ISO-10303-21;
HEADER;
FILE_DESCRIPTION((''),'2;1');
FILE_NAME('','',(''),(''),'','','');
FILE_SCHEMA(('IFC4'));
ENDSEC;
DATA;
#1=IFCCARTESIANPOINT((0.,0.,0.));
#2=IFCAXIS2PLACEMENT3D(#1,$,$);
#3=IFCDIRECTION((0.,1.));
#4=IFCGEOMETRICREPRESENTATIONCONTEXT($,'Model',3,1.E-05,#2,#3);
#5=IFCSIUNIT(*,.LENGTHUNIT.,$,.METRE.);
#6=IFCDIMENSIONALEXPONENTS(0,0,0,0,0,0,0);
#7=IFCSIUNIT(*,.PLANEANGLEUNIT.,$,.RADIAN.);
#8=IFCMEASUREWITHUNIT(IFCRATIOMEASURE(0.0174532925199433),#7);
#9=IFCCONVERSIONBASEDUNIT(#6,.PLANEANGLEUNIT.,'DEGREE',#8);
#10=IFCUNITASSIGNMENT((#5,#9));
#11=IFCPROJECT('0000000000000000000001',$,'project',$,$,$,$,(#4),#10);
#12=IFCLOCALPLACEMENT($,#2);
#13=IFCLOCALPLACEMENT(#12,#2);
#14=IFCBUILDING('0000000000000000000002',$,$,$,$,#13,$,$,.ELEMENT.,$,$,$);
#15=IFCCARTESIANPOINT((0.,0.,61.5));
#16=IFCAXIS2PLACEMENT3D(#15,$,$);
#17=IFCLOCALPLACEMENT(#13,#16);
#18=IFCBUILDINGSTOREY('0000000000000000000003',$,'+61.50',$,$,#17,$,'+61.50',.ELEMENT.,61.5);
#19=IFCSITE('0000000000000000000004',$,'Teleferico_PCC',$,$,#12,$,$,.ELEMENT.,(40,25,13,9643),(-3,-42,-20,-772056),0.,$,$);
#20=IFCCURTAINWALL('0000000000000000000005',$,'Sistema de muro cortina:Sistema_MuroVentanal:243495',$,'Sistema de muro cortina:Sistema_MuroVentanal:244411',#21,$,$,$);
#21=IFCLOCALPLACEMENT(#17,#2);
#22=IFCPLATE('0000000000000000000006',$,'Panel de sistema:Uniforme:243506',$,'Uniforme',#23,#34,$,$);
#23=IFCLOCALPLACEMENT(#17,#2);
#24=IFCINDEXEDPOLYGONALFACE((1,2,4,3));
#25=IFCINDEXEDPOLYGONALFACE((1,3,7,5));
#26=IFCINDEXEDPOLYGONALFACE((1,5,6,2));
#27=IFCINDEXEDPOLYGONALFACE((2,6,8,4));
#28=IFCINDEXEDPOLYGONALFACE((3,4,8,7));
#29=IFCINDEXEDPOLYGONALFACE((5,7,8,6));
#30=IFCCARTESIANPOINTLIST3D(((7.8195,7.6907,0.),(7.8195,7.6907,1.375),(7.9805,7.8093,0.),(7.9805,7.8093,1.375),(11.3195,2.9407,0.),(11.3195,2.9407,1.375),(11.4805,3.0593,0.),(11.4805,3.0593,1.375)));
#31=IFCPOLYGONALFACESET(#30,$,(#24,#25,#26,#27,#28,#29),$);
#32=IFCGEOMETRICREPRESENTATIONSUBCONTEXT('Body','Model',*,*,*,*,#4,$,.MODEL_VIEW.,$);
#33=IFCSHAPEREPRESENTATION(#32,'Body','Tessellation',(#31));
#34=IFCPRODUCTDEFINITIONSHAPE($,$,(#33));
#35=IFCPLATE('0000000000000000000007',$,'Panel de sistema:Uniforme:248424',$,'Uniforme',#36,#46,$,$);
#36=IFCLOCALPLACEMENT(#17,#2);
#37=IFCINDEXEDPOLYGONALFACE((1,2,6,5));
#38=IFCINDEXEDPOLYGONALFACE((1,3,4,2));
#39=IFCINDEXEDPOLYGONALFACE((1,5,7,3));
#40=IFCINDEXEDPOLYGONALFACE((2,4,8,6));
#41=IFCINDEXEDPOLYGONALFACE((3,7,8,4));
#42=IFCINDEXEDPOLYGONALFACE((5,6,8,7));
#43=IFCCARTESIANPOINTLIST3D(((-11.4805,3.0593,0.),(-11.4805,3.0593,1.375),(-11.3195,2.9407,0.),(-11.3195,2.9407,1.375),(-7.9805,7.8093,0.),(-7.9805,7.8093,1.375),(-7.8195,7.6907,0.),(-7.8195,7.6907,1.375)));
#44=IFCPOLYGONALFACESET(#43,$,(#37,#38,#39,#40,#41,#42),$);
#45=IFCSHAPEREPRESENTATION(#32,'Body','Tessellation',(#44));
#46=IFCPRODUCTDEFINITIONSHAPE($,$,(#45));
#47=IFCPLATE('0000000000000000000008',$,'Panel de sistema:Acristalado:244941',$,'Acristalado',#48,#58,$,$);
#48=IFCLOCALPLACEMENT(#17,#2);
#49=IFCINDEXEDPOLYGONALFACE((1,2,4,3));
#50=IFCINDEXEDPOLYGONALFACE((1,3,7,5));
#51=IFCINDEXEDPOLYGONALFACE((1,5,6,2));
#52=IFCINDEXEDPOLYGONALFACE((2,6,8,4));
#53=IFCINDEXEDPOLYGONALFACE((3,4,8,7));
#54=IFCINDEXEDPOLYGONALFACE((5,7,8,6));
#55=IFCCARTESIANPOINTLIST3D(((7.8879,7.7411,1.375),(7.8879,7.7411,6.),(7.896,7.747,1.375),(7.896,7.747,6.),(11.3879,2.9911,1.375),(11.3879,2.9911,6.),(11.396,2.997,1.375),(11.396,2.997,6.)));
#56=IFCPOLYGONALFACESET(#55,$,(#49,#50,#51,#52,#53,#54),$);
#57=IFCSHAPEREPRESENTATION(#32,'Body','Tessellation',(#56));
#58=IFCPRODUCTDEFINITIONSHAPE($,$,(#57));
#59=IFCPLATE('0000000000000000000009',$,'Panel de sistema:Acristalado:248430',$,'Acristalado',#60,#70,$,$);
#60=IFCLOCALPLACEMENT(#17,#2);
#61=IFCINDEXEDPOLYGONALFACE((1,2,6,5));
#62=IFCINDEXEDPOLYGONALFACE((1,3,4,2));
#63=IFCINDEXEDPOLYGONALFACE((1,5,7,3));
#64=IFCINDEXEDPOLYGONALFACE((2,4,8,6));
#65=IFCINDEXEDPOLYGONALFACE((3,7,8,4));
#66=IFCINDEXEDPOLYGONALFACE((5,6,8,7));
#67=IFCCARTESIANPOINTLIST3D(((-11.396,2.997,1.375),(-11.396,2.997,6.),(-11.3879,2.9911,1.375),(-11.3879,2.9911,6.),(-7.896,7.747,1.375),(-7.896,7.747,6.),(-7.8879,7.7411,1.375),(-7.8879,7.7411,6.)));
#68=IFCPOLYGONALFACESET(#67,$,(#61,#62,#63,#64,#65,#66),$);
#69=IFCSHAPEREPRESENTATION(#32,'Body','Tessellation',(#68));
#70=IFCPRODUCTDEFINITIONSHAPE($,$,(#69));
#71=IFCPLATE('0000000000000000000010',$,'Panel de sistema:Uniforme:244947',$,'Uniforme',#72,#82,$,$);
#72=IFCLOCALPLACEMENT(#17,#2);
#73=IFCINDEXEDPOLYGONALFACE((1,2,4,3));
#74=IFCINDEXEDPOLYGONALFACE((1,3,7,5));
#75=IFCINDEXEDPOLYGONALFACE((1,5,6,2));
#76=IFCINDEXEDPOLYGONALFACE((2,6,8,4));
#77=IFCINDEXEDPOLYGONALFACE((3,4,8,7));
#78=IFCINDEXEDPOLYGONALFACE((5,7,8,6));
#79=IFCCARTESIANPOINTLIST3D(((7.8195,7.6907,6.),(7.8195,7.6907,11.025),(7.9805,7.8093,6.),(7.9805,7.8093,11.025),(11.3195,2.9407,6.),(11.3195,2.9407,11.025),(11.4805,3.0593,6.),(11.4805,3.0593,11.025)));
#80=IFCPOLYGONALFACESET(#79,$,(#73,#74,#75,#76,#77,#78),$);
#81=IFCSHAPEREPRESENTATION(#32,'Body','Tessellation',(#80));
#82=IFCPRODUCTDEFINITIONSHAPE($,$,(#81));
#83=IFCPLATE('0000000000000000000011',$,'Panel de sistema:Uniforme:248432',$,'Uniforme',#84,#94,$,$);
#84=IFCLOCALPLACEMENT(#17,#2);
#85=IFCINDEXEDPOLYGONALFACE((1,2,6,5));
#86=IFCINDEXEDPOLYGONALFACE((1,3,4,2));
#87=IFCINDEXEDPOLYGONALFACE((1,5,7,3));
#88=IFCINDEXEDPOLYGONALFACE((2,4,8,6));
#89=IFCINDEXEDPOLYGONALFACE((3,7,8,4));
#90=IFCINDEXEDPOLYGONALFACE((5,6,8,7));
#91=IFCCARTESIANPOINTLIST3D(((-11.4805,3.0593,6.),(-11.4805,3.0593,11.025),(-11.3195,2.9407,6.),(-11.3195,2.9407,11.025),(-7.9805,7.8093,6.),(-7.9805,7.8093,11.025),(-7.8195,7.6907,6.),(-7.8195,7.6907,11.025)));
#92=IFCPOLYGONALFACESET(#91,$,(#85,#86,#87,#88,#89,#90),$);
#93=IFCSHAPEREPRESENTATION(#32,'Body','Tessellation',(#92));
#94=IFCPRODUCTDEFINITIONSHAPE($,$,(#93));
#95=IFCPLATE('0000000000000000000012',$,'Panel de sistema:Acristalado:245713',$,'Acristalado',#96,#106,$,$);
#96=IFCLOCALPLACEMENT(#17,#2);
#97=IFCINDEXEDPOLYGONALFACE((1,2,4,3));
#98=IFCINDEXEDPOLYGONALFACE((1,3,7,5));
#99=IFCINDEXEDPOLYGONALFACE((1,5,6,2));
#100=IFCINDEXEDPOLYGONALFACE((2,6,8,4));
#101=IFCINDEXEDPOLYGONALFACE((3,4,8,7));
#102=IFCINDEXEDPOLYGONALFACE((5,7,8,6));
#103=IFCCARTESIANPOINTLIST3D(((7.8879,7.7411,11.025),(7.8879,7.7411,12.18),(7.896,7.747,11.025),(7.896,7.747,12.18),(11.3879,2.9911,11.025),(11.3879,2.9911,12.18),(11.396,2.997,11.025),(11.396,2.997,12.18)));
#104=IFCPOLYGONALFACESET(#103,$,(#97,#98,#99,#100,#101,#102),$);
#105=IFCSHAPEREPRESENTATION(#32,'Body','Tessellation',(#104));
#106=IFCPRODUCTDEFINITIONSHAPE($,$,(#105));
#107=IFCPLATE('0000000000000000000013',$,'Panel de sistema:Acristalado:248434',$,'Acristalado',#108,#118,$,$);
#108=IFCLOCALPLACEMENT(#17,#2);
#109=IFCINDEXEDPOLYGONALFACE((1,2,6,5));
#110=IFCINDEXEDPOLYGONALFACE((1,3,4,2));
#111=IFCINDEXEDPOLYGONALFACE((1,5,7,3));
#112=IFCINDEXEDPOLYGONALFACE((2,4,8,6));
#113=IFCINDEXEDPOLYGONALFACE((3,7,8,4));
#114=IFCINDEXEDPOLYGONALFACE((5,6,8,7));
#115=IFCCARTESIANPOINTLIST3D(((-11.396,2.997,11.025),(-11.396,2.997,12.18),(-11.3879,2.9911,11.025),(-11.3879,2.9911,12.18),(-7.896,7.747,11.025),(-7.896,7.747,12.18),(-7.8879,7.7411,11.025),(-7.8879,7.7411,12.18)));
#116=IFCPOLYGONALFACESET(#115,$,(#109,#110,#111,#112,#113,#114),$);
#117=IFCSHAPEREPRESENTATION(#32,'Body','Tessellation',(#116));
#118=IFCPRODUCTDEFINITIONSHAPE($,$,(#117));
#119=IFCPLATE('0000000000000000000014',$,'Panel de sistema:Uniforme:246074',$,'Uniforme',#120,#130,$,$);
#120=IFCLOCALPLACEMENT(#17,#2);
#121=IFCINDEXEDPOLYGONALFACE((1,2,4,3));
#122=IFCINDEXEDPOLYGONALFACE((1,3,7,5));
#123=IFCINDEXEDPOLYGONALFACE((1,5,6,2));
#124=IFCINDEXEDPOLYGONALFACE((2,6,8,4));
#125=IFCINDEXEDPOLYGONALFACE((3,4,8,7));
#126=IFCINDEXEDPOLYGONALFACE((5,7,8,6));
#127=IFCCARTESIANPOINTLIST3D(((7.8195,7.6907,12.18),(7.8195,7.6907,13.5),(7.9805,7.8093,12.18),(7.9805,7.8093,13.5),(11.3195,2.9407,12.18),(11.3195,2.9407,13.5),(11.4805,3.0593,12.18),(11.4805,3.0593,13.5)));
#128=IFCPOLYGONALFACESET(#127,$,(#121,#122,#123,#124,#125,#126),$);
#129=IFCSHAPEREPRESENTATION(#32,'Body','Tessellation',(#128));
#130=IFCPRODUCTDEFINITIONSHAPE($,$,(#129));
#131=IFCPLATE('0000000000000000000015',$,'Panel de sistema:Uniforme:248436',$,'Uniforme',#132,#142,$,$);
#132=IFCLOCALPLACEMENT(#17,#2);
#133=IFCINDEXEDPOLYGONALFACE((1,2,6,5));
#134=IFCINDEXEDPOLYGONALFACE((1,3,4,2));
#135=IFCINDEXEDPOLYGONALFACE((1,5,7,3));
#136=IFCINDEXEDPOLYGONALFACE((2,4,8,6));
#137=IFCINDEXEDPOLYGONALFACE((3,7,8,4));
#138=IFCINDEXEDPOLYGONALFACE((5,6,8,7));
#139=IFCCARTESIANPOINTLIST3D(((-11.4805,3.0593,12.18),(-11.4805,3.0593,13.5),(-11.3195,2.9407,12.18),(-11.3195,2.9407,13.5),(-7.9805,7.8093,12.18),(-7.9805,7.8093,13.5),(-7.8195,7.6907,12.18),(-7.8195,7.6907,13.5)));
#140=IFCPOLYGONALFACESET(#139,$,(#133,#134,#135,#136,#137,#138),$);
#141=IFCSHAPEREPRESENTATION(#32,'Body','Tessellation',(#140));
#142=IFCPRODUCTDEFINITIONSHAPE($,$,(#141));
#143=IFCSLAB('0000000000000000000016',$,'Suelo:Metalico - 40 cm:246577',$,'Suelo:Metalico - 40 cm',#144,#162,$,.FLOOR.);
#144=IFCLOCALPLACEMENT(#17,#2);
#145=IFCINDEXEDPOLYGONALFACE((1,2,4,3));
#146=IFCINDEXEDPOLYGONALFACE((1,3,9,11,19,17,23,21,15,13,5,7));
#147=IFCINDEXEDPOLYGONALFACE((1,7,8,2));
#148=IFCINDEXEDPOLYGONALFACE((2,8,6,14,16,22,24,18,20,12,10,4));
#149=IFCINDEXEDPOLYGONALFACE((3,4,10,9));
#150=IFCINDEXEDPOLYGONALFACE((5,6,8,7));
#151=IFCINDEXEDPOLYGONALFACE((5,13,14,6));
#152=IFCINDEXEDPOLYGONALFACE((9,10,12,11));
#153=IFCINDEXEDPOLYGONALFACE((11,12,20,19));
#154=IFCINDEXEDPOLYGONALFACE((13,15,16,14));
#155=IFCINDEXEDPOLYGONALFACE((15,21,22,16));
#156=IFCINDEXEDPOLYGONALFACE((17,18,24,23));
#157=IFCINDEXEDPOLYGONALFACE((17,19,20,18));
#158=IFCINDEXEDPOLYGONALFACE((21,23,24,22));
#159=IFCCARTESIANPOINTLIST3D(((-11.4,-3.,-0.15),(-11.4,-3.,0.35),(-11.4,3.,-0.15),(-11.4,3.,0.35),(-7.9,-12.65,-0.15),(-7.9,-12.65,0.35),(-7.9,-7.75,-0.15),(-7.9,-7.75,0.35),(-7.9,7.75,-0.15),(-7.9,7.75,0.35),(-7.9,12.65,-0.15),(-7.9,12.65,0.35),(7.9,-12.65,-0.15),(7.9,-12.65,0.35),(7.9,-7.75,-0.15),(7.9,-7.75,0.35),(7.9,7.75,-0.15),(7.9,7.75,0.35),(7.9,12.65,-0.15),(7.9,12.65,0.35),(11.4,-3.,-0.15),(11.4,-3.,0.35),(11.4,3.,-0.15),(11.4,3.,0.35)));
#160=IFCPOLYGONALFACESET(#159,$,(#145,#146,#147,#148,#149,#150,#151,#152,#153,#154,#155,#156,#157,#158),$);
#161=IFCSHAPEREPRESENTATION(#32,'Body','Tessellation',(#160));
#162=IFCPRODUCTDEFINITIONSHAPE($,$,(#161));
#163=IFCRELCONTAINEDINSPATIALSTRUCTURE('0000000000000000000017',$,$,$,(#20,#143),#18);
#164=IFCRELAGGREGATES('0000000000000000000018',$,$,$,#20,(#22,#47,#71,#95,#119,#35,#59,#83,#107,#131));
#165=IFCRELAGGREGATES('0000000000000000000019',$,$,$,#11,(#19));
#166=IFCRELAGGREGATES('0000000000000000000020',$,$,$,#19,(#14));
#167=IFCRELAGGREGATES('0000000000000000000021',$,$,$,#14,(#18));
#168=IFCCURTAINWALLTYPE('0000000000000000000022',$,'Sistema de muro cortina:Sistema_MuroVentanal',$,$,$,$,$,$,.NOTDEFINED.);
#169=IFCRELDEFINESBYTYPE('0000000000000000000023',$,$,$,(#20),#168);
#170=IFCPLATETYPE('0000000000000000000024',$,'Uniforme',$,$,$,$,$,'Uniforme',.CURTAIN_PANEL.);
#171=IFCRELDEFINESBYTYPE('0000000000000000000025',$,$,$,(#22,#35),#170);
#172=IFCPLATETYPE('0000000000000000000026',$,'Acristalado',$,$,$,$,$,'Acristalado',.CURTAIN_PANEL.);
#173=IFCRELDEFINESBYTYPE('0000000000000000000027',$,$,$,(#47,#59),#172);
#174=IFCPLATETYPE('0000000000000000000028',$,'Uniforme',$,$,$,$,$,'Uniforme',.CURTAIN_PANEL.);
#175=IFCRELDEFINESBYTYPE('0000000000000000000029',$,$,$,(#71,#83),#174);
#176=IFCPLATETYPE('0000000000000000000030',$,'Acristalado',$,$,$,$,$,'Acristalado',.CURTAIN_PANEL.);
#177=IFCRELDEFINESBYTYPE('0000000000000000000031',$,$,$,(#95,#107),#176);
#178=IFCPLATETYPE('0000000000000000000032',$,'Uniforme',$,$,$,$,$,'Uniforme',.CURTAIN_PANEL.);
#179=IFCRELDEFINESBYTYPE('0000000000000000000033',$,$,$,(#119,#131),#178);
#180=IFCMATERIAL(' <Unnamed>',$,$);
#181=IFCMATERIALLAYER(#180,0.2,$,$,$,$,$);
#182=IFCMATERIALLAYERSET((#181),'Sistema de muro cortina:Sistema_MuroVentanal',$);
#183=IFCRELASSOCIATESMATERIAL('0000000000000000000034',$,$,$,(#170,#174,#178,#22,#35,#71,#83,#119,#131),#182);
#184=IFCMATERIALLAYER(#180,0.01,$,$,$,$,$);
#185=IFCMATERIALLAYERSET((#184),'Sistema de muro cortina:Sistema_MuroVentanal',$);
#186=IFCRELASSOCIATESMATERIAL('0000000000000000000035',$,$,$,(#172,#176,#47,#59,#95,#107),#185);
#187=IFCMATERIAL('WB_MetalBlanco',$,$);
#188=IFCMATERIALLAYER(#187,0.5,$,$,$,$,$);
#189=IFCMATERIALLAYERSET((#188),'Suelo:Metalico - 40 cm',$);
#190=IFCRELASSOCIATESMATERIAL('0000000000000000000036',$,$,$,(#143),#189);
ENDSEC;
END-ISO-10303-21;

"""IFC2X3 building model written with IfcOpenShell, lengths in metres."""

from ifc_helpers import new_model, entity, si_unit, converted_unit, direction, frame, frame_2d, origin, origin_2d_with_axis, place, context, subcontext, project, spatial, polyline, rectangle, outline, extrude, source, transform, mapped, material, layer, layer_set, layer_usage, type_object, type_shapes, element, aggregate, save


model = new_model("IFC2X3")

# Units and contexts
model_context = context("Model", 3, precision=1e-05, world=origin(), true_north=direction((0.0, 1.0)))
body_context = subcontext(model_context, "Body", "Model", "MODEL_VIEW")
ifc_project = project(units=[si_unit("LENGTHUNIT", "METRE"), converted_unit("PLANEANGLEUNIT", "DEGREE", entity("IfcRatioMeasure", 0.0174532925199433), si_unit("PLANEANGLEUNIT", "RADIAN"), dimensions=[0, 0, 0, 0, 0, 0, 0])], contexts=[model_context])

# Site, building, storey
site_placement = place(None, origin())
site = spatial("IfcSite", under=ifc_project, at=site_placement, Name="Teleferico_PCC", CompositionType="ELEMENT", RefLatitude=(40, 25, 13, 9643), RefLongitude=(-3, -42, -20, -772056), RefElevation=0.0)
building_placement = place(site_placement, origin())
building = spatial("IfcBuilding", under=site, at=building_placement, CompositionType="ELEMENT")
storey_placement = place(building_placement, frame((0.0, 0.0, 61.5)))
storey = spatial("IfcBuildingStorey", under=building, at=storey_placement, Name="+61.50", LongName="+61.50", CompositionType="ELEMENT", Elevation=61.5)

# Curtain wall, plates
curtain_wall_type = type_object("IfcCurtainWallType", Name="Sistema de muro cortina:Sistema_MuroVentanal", PredefinedType="NOTDEFINED")
curtain_wall_placement = place(storey_placement, frame((0.0, 0.0, -61.5)))
curtain_wall = element("IfcCurtainWall", 1, at=curtain_wall_placement, inside=storey, type_object=curtain_wall_type, Name="Sistema de muro cortina:Sistema_MuroVentanal:243495", ObjectType="Sistema de muro cortina:Sistema_MuroVentanal:244411")
ifc_material_1 = material(Name=" <Unnamed>")
ifc_layer_1 = layer(ifc_material_1, 0.2)
ifc_layer_set_1 = layer_set([ifc_layer_1], Name="Sistema de muro cortina:Sistema_MuroVentanal")
ifc_layer_2 = layer(ifc_material_1, 0.01)
ifc_layer_set_2 = layer_set([ifc_layer_2], Name="Sistema de muro cortina:Sistema_MuroVentanal")
ifc_layer_usage_1 = layer_usage(ifc_layer_set_1, "AXIS3", "POSITIVE", 0.0)
plate_type_1 = type_object("IfcPlateType", Name="Uniforme", ElementType="Uniforme", PredefinedType="CURTAIN_PANEL", material=ifc_layer_set_1)
shared_shape_1 = source(origin(), body_context, "Body", "SweptSolid", [
    extrude(rectangle(XDim=0.2, YDim=5.9002, at=origin_2d_with_axis()), frame((0.0, 0.0, 0.0), z_axis=(0.0, 0.0, 1.0), x_axis=(0.0, 1.0, 0.0)), (0.0, 0.0, 1.0), 1.375),
])
type_shapes(plate_type_1, [shared_shape_1])
plate_1_placement = place(curtain_wall_placement, frame((9.65, 5.375, 61.5), z_axis=(0.0, 0.0, 1.0), x_axis=(0.593199, -0.805056, 0.0)))
plate_1 = element("IfcPlate", 2, at=plate_1_placement, type_object=plate_type_1, material=ifc_layer_usage_1, Name="Panel de sistema:Uniforme:243506", ObjectType="Uniforme", context=body_context, shape_type="MappedRepresentation", body=[
    mapped(shared_shape_1, transform((0.0, 0.0, 0.0), scale=1.0)),
])
ifc_layer_usage_2 = layer_usage(ifc_layer_set_1, "AXIS3", "POSITIVE", 0.0)
plate_2_placement = place(curtain_wall_placement, frame((-9.65, 5.375, 61.5), z_axis=(0.0, 0.0, 1.0), x_axis=(0.593199, 0.805056, 0.0)))
plate_2 = element("IfcPlate", 3, at=plate_2_placement, type_object=plate_type_1, material=ifc_layer_usage_2, Name="Panel de sistema:Uniforme:248424", ObjectType="Uniforme", context=body_context, shape_type="MappedRepresentation", body=[
    mapped(shared_shape_1, transform((0.0, 0.0, 0.0), scale=1.0)),
])
ifc_layer_usage_3 = layer_usage(ifc_layer_set_2, "AXIS3", "POSITIVE", -0.0328)
plate_type_2 = type_object("IfcPlateType", Name="Acristalado", ElementType="Acristalado", PredefinedType="CURTAIN_PANEL", material=ifc_layer_set_2)
shared_shape_2 = source(origin(), body_context, "Body", "SweptSolid", [
    extrude(rectangle(XDim=0.01, YDim=5.9002, at=origin_2d_with_axis()), frame((2.9501, 0.005, 0.0), z_axis=(0.0, 0.0, 1.0), x_axis=(0.0, 1.0, 0.0)), (0.0, 0.0, 1.0), 4.625),
])
type_shapes(plate_type_2, [shared_shape_2])
plate_3_placement = place(curtain_wall_placement, frame((7.8879, 7.7411, 62.875), z_axis=(0.0, 0.0, 1.0), x_axis=(0.593199, -0.805056, 0.0)))
plate_3 = element("IfcPlate", 4, at=plate_3_placement, type_object=plate_type_2, material=ifc_layer_usage_3, Name="Panel de sistema:Acristalado:244941", ObjectType="Acristalado", context=body_context, shape_type="MappedRepresentation", body=[
    mapped(shared_shape_2, transform((0.0, 0.0, 0.0), scale=1.0)),
])
ifc_layer_usage_4 = layer_usage(ifc_layer_set_2, "AXIS3", "POSITIVE", -0.0328)
plate_4_placement = place(curtain_wall_placement, frame((-11.3879, 2.9911, 62.875), z_axis=(0.0, 0.0, 1.0), x_axis=(0.593199, 0.805056, 0.0)))
plate_4 = element("IfcPlate", 5, at=plate_4_placement, type_object=plate_type_2, material=ifc_layer_usage_4, Name="Panel de sistema:Acristalado:248430", ObjectType="Acristalado", context=body_context, shape_type="MappedRepresentation", body=[
    mapped(shared_shape_2, transform((0.0, 0.0, 0.0), scale=1.0)),
])
ifc_layer_usage_5 = layer_usage(ifc_layer_set_1, "AXIS3", "POSITIVE", 0.0)
plate_type_3 = type_object("IfcPlateType", Name="Uniforme", ElementType="Uniforme", PredefinedType="CURTAIN_PANEL", material=ifc_layer_set_1)
shared_shape_3 = source(origin(), body_context, "Body", "SweptSolid", [
    extrude(rectangle(XDim=0.2, YDim=5.9002, at=origin_2d_with_axis()), frame((0.0, 0.0, 0.0), z_axis=(0.0, 0.0, 1.0), x_axis=(0.0, 1.0, 0.0)), (0.0, 0.0, 1.0), 5.025),
])
type_shapes(plate_type_3, [shared_shape_3])
plate_5_placement = place(curtain_wall_placement, frame((9.65, 5.375, 67.5), z_axis=(0.0, 0.0, 1.0), x_axis=(0.593199, -0.805056, 0.0)))
plate_5 = element("IfcPlate", 6, at=plate_5_placement, type_object=plate_type_3, material=ifc_layer_usage_5, Name="Panel de sistema:Uniforme:244947", ObjectType="Uniforme", context=body_context, shape_type="MappedRepresentation", body=[
    mapped(shared_shape_3, transform((0.0, 0.0, 0.0), scale=1.0)),
])
ifc_layer_usage_6 = layer_usage(ifc_layer_set_1, "AXIS3", "POSITIVE", 0.0)
plate_6_placement = place(curtain_wall_placement, frame((-9.65, 5.375, 67.5), z_axis=(0.0, 0.0, 1.0), x_axis=(0.593199, 0.805056, 0.0)))
plate_6 = element("IfcPlate", 7, at=plate_6_placement, type_object=plate_type_3, material=ifc_layer_usage_6, Name="Panel de sistema:Uniforme:248432", ObjectType="Uniforme", context=body_context, shape_type="MappedRepresentation", body=[
    mapped(shared_shape_3, transform((0.0, 0.0, 0.0), scale=1.0)),
])
ifc_layer_usage_7 = layer_usage(ifc_layer_set_2, "AXIS3", "POSITIVE", -0.0328)
plate_type_4 = type_object("IfcPlateType", Name="Acristalado", ElementType="Acristalado", PredefinedType="CURTAIN_PANEL", material=ifc_layer_set_2)
shared_shape_4 = source(origin(), body_context, "Body", "SweptSolid", [
    extrude(rectangle(XDim=0.01, YDim=5.9002, at=frame_2d((0.0, 0.0), x_axis=(1.0, 0.0))), frame((2.9501, 0.005, 0.0), z_axis=(0.0, 0.0, 1.0), x_axis=(0.0, 1.0, 0.0)), (0.0, 0.0, 1.0), 1.155),
])
type_shapes(plate_type_4, [shared_shape_4])
plate_7_placement = place(curtain_wall_placement, frame((7.8879, 7.7411, 72.525), z_axis=(0.0, 0.0, 1.0), x_axis=(0.593199, -0.805056, 0.0)))
plate_7 = element("IfcPlate", 8, at=plate_7_placement, type_object=plate_type_4, material=ifc_layer_usage_7, Name="Panel de sistema:Acristalado:245713", ObjectType="Acristalado", context=body_context, shape_type="MappedRepresentation", body=[
    mapped(shared_shape_4, transform((0.0, 0.0, 0.0), scale=1.0)),
])
ifc_layer_usage_8 = layer_usage(ifc_layer_set_2, "AXIS3", "POSITIVE", -0.0328)
plate_8_placement = place(curtain_wall_placement, frame((-11.3879, 2.9911, 72.525), z_axis=(0.0, 0.0, 1.0), x_axis=(0.593199, 0.805056, 0.0)))
plate_8 = element("IfcPlate", 9, at=plate_8_placement, type_object=plate_type_4, material=ifc_layer_usage_8, Name="Panel de sistema:Acristalado:248434", ObjectType="Acristalado", context=body_context, shape_type="MappedRepresentation", body=[
    mapped(shared_shape_4, transform((0.0, 0.0, 0.0), scale=1.0)),
])
ifc_layer_usage_9 = layer_usage(ifc_layer_set_1, "AXIS3", "POSITIVE", 0.0)
plate_type_5 = type_object("IfcPlateType", Name="Uniforme", ElementType="Uniforme", PredefinedType="CURTAIN_PANEL", material=ifc_layer_set_1)
shared_shape_5 = source(origin(), body_context, "Body", "SweptSolid", [
    extrude(rectangle(XDim=0.2, YDim=5.9002, at=origin_2d_with_axis()), frame((0.0, 0.0, 0.0), z_axis=(0.0, 0.0, 1.0), x_axis=(0.0, 1.0, 0.0)), (0.0, 0.0, 1.0), 1.32),
])
type_shapes(plate_type_5, [shared_shape_5])
plate_9_placement = place(curtain_wall_placement, frame((9.65, 5.375, 73.68), z_axis=(0.0, 0.0, 1.0), x_axis=(0.593199, -0.805056, 0.0)))
plate_9 = element("IfcPlate", 10, at=plate_9_placement, type_object=plate_type_5, material=ifc_layer_usage_9, Name="Panel de sistema:Uniforme:246074", ObjectType="Uniforme", context=body_context, shape_type="MappedRepresentation", body=[
    mapped(shared_shape_5, transform((0.0, 0.0, 0.0), scale=1.0)),
])
ifc_layer_usage_10 = layer_usage(ifc_layer_set_1, "AXIS3", "POSITIVE", 0.0)
plate_10_placement = place(curtain_wall_placement, frame((-9.65, 5.375, 73.68), z_axis=(0.0, 0.0, 1.0), x_axis=(0.593199, 0.805056, 0.0)))
plate_10 = element("IfcPlate", 11, at=plate_10_placement, type_object=plate_type_5, material=ifc_layer_usage_10, Name="Panel de sistema:Uniforme:248436", ObjectType="Uniforme", context=body_context, shape_type="MappedRepresentation", body=[
    mapped(shared_shape_5, transform((0.0, 0.0, 0.0), scale=1.0)),
])
aggregate(curtain_wall, [plate_1, plate_3, plate_5, plate_7, plate_9, plate_2, plate_4, plate_6, plate_8, plate_10])

# Slab
ifc_material_2 = material(Name="WB_MetalBlanco")
ifc_layer_3 = layer(ifc_material_2, 0.5)
ifc_layer_set_3 = layer_set([ifc_layer_3], Name="Suelo:Metalico - 40 cm")
ifc_layer_usage_11 = layer_usage(ifc_layer_set_3, "AXIS3", "POSITIVE", 0.0)
slab_placement = place(storey_placement, origin())
element("IfcSlab", 12, at=slab_placement, inside=storey, material=ifc_layer_usage_11, Name="Suelo:Metalico - 40 cm:246577", ObjectType="Suelo:Metalico - 40 cm", PredefinedType="FLOOR", context=body_context, shape_type="SweptSolid", body=[
    extrude(outline(polyline([(-3.0, -11.4), (3.0, -11.4), (7.75, -7.9), (12.65, -7.9), (12.65, 7.9), (7.75, 7.9), (3.0, 11.4), (-3.0, 11.4), (-7.75, 7.9), (-12.65, 7.9), (-12.65, -7.9), (-7.75, -7.9), (-3.0, -11.4)])), frame((0.0, 0.0, 0.35), z_axis=(0.0, 0.0, -1.0), x_axis=(0.0, 1.0, 0.0)), (0.0, 0.0, 1.0), 0.5),
])

save(model, "model.ifc")
